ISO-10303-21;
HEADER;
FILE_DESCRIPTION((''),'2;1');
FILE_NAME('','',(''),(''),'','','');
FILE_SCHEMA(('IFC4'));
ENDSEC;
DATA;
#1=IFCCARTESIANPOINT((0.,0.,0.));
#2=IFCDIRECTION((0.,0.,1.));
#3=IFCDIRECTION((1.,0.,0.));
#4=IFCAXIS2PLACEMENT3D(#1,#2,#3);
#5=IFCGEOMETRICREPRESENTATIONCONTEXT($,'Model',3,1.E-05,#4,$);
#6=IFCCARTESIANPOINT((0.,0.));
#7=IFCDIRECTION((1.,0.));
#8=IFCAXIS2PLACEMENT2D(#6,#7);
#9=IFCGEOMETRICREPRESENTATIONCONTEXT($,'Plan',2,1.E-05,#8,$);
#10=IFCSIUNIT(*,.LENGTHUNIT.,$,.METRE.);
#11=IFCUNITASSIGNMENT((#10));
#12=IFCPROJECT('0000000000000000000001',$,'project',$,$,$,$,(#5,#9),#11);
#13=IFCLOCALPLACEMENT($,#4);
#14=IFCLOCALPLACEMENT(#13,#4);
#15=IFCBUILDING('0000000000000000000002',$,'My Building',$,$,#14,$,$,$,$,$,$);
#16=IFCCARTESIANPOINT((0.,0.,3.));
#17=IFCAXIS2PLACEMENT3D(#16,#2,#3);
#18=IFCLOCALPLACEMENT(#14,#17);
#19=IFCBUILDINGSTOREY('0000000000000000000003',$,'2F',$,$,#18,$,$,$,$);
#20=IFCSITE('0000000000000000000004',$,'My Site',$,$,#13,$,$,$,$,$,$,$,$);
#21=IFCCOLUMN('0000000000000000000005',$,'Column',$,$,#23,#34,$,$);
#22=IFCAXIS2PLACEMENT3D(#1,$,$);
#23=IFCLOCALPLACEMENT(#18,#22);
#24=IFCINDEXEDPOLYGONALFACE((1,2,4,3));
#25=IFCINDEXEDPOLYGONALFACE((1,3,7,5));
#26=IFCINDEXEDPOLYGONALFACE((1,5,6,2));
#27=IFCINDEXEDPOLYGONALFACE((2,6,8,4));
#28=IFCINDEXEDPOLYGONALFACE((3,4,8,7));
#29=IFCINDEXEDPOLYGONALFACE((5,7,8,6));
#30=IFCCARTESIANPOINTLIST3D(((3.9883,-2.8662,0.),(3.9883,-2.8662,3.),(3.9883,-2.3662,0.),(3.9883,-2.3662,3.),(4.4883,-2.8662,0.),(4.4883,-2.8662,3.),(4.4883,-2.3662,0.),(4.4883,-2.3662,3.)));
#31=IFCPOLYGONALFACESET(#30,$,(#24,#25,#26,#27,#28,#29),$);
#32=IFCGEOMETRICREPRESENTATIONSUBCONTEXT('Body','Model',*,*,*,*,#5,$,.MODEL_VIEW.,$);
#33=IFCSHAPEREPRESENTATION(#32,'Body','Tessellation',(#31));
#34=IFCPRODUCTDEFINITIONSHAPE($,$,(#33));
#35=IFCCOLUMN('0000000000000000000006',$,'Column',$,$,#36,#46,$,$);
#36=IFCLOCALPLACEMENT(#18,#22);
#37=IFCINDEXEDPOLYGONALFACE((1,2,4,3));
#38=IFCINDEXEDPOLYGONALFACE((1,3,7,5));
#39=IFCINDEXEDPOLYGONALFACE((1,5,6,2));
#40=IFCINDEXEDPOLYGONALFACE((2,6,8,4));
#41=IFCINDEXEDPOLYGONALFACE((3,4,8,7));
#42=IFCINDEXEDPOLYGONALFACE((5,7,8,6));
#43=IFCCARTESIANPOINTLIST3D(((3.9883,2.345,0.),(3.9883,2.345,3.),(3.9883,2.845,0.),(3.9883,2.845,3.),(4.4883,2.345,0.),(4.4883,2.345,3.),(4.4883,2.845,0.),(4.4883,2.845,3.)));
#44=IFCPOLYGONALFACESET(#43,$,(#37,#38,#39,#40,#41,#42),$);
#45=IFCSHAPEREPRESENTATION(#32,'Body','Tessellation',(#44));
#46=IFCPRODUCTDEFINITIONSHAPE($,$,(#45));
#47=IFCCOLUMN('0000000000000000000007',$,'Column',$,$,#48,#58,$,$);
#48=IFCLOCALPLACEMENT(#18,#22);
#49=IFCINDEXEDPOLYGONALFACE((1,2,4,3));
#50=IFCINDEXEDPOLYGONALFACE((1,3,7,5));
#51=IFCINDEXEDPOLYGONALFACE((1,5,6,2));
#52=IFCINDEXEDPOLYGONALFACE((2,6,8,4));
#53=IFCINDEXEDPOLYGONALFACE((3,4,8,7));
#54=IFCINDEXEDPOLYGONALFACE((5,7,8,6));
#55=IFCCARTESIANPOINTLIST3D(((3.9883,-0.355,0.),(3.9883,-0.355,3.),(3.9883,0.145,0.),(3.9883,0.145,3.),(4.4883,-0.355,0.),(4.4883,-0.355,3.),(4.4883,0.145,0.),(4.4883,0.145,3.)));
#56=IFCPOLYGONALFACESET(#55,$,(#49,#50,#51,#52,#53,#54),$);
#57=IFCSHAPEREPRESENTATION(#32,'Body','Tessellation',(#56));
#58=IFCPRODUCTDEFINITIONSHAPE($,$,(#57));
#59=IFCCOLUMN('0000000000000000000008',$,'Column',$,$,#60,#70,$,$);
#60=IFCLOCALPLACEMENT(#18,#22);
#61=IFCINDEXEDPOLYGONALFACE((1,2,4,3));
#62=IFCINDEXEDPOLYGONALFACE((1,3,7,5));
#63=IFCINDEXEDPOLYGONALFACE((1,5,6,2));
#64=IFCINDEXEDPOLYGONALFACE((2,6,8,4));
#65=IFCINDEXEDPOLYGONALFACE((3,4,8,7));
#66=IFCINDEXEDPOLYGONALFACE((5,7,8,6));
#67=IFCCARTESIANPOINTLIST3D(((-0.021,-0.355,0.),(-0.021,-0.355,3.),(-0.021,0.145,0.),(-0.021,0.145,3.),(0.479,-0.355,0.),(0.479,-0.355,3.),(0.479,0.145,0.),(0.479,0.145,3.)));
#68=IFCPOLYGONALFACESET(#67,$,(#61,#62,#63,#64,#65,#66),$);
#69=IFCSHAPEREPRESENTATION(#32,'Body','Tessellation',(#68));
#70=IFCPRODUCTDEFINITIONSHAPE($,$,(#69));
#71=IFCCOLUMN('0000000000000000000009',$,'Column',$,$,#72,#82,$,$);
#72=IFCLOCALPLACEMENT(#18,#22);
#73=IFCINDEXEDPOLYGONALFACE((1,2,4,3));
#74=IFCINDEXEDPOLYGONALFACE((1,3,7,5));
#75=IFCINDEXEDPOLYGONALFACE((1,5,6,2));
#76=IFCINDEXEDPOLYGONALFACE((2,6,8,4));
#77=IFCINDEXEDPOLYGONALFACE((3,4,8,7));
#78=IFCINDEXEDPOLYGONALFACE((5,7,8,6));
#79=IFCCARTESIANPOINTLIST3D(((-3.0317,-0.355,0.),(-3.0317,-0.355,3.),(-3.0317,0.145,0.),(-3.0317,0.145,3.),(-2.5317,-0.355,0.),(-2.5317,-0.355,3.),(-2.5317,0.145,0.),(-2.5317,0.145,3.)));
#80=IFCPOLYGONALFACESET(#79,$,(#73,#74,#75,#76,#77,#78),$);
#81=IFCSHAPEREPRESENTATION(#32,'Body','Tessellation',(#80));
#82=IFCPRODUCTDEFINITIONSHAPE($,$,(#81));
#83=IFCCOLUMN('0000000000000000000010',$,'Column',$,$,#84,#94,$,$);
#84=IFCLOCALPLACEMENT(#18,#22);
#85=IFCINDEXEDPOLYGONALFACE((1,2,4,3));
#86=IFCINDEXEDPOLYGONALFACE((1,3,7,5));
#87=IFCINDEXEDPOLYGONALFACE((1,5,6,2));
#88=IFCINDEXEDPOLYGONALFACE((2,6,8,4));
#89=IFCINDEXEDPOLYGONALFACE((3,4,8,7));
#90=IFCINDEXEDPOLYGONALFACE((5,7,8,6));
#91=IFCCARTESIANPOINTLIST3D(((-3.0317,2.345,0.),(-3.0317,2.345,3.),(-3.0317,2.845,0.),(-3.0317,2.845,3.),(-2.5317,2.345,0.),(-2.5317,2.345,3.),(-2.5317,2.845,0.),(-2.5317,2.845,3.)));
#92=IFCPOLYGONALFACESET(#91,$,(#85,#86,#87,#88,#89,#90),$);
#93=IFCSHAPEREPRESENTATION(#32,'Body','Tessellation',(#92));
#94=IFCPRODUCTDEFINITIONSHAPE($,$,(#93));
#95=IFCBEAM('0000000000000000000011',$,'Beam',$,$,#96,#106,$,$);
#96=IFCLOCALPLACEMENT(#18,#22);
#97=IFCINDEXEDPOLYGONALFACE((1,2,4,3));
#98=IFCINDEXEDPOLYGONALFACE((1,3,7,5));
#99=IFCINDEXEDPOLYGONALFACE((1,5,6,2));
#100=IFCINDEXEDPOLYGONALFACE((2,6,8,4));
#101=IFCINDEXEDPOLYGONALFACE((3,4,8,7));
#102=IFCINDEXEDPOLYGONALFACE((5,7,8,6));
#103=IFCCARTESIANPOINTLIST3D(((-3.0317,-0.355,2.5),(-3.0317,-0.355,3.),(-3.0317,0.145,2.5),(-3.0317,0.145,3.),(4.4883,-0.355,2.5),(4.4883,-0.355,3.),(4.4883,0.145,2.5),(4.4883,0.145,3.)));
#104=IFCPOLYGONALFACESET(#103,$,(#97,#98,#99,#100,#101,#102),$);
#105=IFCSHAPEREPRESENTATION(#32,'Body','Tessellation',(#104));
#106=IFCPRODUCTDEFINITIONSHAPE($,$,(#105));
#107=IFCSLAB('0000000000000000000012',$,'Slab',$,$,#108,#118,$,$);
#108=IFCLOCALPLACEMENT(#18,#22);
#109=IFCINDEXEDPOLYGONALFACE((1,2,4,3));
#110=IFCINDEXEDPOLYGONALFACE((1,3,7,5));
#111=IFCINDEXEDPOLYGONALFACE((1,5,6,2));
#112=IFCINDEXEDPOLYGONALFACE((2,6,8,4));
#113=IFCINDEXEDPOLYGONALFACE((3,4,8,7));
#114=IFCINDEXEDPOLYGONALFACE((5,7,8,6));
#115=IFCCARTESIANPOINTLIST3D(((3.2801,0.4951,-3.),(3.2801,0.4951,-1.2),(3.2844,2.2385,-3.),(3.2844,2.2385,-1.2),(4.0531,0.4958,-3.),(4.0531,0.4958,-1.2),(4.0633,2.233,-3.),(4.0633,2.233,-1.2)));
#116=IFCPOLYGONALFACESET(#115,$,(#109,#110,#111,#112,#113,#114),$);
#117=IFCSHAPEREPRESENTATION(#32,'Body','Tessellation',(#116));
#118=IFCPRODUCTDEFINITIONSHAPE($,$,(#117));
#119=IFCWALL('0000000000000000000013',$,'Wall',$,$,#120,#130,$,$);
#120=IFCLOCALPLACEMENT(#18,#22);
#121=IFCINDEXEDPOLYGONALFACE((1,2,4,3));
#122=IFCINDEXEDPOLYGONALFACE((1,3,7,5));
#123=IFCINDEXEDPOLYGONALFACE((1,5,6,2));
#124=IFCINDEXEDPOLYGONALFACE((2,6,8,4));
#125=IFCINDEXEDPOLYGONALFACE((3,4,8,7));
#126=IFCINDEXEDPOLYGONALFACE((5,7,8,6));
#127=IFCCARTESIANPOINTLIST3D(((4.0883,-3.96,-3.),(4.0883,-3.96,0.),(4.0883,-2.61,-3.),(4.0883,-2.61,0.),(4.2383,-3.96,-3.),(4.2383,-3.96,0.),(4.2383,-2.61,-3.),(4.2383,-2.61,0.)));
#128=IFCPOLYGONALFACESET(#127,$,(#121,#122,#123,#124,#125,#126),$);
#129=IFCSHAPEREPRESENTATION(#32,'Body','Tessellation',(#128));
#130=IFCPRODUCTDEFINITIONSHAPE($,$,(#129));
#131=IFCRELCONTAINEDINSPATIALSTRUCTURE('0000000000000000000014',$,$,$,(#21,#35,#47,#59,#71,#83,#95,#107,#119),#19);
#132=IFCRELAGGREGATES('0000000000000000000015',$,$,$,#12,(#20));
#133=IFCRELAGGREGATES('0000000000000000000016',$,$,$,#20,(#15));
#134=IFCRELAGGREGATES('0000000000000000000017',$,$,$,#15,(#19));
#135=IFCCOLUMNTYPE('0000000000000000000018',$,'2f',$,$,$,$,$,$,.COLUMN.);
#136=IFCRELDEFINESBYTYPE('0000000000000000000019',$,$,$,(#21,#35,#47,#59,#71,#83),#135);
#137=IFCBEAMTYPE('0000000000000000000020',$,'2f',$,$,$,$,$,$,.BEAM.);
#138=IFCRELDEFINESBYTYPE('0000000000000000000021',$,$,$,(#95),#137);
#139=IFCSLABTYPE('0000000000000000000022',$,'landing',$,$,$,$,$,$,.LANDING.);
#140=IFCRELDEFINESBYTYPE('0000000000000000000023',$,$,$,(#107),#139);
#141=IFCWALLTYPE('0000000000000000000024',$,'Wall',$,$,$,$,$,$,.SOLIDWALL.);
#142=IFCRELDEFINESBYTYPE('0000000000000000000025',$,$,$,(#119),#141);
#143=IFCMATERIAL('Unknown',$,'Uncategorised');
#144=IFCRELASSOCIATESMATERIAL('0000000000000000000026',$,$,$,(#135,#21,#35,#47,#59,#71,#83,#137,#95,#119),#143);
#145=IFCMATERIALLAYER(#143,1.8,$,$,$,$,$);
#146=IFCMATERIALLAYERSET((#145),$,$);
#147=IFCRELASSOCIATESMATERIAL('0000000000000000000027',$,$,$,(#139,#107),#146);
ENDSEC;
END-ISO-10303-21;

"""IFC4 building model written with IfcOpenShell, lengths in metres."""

from ifc_helpers import new_model, si_unit, frame, origin_with_axes, origin_2d_with_axis, place, context, subcontext, project, spatial, line, indexed_curve, rectangle, outline, extrude, material, layer, layer_set, layer_usage, material_profile, profile_set, profile_usage, type_object, element, save


model = new_model("IFC4")

# Units and contexts
model_context = context("Model", 3, precision=1e-05, world=origin_with_axes())
plan_context = context("Plan", 2, precision=1e-05, world=origin_2d_with_axis())
body_context_1 = subcontext(model_context, "Body", "Model", "MODEL_VIEW")
ifc_project = project(units=[si_unit("LENGTHUNIT", "METRE")], contexts=[model_context, plan_context])

# Site, building, storey
site_placement = place(None, origin_with_axes())
site = spatial("IfcSite", under=ifc_project, at=site_placement, Name="My Site")
building_placement = place(site_placement, origin_with_axes())
building = spatial("IfcBuilding", under=site, at=building_placement, Name="My Building")
storey_placement = place(building_placement, frame((0.0, 0.0, 3.0), z_axis=(0.0, 0.0, 1.0), x_axis=(1.0, 0.0, 0.0)))
storey = spatial("IfcBuildingStorey", under=building, at=storey_placement, Name="2F")

# Columns
ifc_material = material(Name="Unknown", Category="Uncategorised")
ifc_material_profile_1 = material_profile(ifc_material, rectangle(XDim=0.5, YDim=0.5))
ifc_profile_set_1 = profile_set([ifc_material_profile_1])
ifc_profile_usage_1 = profile_usage(ifc_profile_set_1, cardinal=5)
column_type = type_object("IfcColumnType", Name="2f", PredefinedType="COLUMN", material=ifc_profile_set_1)
column_1_placement = place(storey_placement, frame((4.2383, -2.6162, 0.0), z_axis=(0.0, 0.0, 1.0), x_axis=(1.0, 0.0, 0.0)))
element("IfcColumn", 1, at=column_1_placement, inside=storey, type_object=column_type, material=ifc_profile_usage_1, Name="Column", context=body_context_1, shape_type="SweptSolid", body=[
    extrude(rectangle(XDim=0.5, YDim=0.5), origin_with_axes(), (0.0, 0.0, 1.0), 3.0),
])
ifc_profile_usage_2 = profile_usage(ifc_profile_set_1, cardinal=5)
column_2_placement = place(storey_placement, frame((4.2383, 2.595, 0.0), z_axis=(0.0, 0.0, 1.0), x_axis=(1.0, 0.0, 0.0)))
element("IfcColumn", 2, at=column_2_placement, inside=storey, type_object=column_type, material=ifc_profile_usage_2, Name="Column", context=body_context_1, shape_type="SweptSolid", body=[
    extrude(rectangle(XDim=0.5, YDim=0.5), origin_with_axes(), (0.0, 0.0, 1.0), 3.0),
])
ifc_profile_usage_3 = profile_usage(ifc_profile_set_1, cardinal=5)
column_3_placement = place(storey_placement, frame((4.2383, -0.105, 0.0), z_axis=(0.0, 0.0, 1.0), x_axis=(1.0, 0.0, 0.0)))
element("IfcColumn", 3, at=column_3_placement, inside=storey, type_object=column_type, material=ifc_profile_usage_3, Name="Column", context=body_context_1, shape_type="SweptSolid", body=[
    extrude(rectangle(XDim=0.5, YDim=0.5), origin_with_axes(), (0.0, 0.0, 1.0), 3.0),
])
ifc_profile_usage_4 = profile_usage(ifc_profile_set_1, cardinal=5)
column_4_placement = place(storey_placement, frame((0.229, -0.105, 0.0), z_axis=(0.0, 0.0, 1.0), x_axis=(1.0, 0.0, 0.0)))
element("IfcColumn", 4, at=column_4_placement, inside=storey, type_object=column_type, material=ifc_profile_usage_4, Name="Column", context=body_context_1, shape_type="SweptSolid", body=[
    extrude(rectangle(XDim=0.5, YDim=0.5), origin_with_axes(), (0.0, 0.0, 1.0), 3.0),
])
ifc_profile_usage_5 = profile_usage(ifc_profile_set_1, cardinal=5)
column_5_placement = place(storey_placement, frame((-2.7817, -0.105, 0.0), z_axis=(0.0, 0.0, 1.0), x_axis=(1.0, 0.0, 0.0)))
element("IfcColumn", 5, at=column_5_placement, inside=storey, type_object=column_type, material=ifc_profile_usage_5, Name="Column", context=body_context_1, shape_type="SweptSolid", body=[
    extrude(rectangle(XDim=0.5, YDim=0.5), origin_with_axes(), (0.0, 0.0, 1.0), 3.0),
])
ifc_profile_usage_6 = profile_usage(ifc_profile_set_1, cardinal=5)
column_6_placement = place(storey_placement, frame((-2.7817, 2.595, 0.0), z_axis=(0.0, 0.0, 1.0), x_axis=(1.0, 0.0, 0.0)))
element("IfcColumn", 6, at=column_6_placement, inside=storey, type_object=column_type, material=ifc_profile_usage_6, Name="Column", context=body_context_1, shape_type="SweptSolid", body=[
    extrude(rectangle(XDim=0.5, YDim=0.5), origin_with_axes(), (0.0, 0.0, 1.0), 3.0),
])

# Beam
ifc_material_profile_2 = material_profile(ifc_material, rectangle(XDim=0.5, YDim=0.5))
ifc_profile_set_2 = profile_set([ifc_material_profile_2])
ifc_profile_usage_7 = profile_usage(ifc_profile_set_2, cardinal=5)
beam_type = type_object("IfcBeamType", Name="2f", PredefinedType="BEAM", material=ifc_profile_set_2)
beam_placement = place(storey_placement, frame((4.4883, -0.105, 2.75), z_axis=(-1.0, 0.0, 0.0), x_axis=(0.0, -1.0, 0.0)))
element("IfcBeam", 7, at=beam_placement, inside=storey, type_object=beam_type, material=ifc_profile_usage_7, Name="Beam", context=body_context_1, shape_type="SweptSolid", body=[
    extrude(rectangle(XDim=0.5, YDim=0.5), origin_with_axes(), (0.0, 0.0, 1.0), 7.52),
])

# Slab
ifc_layer = layer(ifc_material, 1.8)
ifc_layer_set = layer_set([ifc_layer])
ifc_layer_usage = layer_usage(ifc_layer_set, "AXIS3", "POSITIVE", -0.25)
slab_type = type_object("IfcSlabType", Name="landing", PredefinedType="LANDING", material=ifc_layer_set)
slab_placement = place(storey_placement, frame((3.2844, 2.2385, -2.75), z_axis=(0.0, 0.0, 1.0), x_axis=(1.0, 0.0, 0.0)))
element("IfcSlab", 8, at=slab_placement, inside=storey, type_object=slab_type, material=ifc_layer_usage, Name="Slab", context=body_context_1, shape_type="SweptSolid", body=[
    extrude(outline(indexed_curve([(0.779, -0.0055), (0.7688, -1.7427), (-0.0042, -1.7434), (0.0, 0.0), (0.779, -0.0055)])), frame((0.0, 0.0, -0.25), z_axis=(0.0, 0.0, 1.0), x_axis=(1.0, 0.0, 0.0)), (0.0, 0.0, 1.0), 1.8),
])

# Wall
wall_type_1 = type_object("IfcWallType", Name="Wall", PredefinedType="SOLIDWALL")
wall_1_placement = place(storey_placement, frame((4.0883, -2.61, -3.0), z_axis=(0.0, 0.0, 1.0), x_axis=(0.0, -1.0, 0.0)))
element("IfcWall", 9, at=wall_1_placement, inside=storey, type_object=wall_type_1, material=ifc_material, Name="Wall", context=body_context_1, shape_type="SweptSolid", body=[
    extrude(outline(indexed_curve([(0.0, 0.0), (0.0, 0.15), (1.35, 0.15), (1.35, 0.0)], segments=[line(1, 2, 3, 4, 1)])), origin_with_axes(), (0.0, 0.0, 1.0), 3.0),
])

save(model, "model.ifc")
